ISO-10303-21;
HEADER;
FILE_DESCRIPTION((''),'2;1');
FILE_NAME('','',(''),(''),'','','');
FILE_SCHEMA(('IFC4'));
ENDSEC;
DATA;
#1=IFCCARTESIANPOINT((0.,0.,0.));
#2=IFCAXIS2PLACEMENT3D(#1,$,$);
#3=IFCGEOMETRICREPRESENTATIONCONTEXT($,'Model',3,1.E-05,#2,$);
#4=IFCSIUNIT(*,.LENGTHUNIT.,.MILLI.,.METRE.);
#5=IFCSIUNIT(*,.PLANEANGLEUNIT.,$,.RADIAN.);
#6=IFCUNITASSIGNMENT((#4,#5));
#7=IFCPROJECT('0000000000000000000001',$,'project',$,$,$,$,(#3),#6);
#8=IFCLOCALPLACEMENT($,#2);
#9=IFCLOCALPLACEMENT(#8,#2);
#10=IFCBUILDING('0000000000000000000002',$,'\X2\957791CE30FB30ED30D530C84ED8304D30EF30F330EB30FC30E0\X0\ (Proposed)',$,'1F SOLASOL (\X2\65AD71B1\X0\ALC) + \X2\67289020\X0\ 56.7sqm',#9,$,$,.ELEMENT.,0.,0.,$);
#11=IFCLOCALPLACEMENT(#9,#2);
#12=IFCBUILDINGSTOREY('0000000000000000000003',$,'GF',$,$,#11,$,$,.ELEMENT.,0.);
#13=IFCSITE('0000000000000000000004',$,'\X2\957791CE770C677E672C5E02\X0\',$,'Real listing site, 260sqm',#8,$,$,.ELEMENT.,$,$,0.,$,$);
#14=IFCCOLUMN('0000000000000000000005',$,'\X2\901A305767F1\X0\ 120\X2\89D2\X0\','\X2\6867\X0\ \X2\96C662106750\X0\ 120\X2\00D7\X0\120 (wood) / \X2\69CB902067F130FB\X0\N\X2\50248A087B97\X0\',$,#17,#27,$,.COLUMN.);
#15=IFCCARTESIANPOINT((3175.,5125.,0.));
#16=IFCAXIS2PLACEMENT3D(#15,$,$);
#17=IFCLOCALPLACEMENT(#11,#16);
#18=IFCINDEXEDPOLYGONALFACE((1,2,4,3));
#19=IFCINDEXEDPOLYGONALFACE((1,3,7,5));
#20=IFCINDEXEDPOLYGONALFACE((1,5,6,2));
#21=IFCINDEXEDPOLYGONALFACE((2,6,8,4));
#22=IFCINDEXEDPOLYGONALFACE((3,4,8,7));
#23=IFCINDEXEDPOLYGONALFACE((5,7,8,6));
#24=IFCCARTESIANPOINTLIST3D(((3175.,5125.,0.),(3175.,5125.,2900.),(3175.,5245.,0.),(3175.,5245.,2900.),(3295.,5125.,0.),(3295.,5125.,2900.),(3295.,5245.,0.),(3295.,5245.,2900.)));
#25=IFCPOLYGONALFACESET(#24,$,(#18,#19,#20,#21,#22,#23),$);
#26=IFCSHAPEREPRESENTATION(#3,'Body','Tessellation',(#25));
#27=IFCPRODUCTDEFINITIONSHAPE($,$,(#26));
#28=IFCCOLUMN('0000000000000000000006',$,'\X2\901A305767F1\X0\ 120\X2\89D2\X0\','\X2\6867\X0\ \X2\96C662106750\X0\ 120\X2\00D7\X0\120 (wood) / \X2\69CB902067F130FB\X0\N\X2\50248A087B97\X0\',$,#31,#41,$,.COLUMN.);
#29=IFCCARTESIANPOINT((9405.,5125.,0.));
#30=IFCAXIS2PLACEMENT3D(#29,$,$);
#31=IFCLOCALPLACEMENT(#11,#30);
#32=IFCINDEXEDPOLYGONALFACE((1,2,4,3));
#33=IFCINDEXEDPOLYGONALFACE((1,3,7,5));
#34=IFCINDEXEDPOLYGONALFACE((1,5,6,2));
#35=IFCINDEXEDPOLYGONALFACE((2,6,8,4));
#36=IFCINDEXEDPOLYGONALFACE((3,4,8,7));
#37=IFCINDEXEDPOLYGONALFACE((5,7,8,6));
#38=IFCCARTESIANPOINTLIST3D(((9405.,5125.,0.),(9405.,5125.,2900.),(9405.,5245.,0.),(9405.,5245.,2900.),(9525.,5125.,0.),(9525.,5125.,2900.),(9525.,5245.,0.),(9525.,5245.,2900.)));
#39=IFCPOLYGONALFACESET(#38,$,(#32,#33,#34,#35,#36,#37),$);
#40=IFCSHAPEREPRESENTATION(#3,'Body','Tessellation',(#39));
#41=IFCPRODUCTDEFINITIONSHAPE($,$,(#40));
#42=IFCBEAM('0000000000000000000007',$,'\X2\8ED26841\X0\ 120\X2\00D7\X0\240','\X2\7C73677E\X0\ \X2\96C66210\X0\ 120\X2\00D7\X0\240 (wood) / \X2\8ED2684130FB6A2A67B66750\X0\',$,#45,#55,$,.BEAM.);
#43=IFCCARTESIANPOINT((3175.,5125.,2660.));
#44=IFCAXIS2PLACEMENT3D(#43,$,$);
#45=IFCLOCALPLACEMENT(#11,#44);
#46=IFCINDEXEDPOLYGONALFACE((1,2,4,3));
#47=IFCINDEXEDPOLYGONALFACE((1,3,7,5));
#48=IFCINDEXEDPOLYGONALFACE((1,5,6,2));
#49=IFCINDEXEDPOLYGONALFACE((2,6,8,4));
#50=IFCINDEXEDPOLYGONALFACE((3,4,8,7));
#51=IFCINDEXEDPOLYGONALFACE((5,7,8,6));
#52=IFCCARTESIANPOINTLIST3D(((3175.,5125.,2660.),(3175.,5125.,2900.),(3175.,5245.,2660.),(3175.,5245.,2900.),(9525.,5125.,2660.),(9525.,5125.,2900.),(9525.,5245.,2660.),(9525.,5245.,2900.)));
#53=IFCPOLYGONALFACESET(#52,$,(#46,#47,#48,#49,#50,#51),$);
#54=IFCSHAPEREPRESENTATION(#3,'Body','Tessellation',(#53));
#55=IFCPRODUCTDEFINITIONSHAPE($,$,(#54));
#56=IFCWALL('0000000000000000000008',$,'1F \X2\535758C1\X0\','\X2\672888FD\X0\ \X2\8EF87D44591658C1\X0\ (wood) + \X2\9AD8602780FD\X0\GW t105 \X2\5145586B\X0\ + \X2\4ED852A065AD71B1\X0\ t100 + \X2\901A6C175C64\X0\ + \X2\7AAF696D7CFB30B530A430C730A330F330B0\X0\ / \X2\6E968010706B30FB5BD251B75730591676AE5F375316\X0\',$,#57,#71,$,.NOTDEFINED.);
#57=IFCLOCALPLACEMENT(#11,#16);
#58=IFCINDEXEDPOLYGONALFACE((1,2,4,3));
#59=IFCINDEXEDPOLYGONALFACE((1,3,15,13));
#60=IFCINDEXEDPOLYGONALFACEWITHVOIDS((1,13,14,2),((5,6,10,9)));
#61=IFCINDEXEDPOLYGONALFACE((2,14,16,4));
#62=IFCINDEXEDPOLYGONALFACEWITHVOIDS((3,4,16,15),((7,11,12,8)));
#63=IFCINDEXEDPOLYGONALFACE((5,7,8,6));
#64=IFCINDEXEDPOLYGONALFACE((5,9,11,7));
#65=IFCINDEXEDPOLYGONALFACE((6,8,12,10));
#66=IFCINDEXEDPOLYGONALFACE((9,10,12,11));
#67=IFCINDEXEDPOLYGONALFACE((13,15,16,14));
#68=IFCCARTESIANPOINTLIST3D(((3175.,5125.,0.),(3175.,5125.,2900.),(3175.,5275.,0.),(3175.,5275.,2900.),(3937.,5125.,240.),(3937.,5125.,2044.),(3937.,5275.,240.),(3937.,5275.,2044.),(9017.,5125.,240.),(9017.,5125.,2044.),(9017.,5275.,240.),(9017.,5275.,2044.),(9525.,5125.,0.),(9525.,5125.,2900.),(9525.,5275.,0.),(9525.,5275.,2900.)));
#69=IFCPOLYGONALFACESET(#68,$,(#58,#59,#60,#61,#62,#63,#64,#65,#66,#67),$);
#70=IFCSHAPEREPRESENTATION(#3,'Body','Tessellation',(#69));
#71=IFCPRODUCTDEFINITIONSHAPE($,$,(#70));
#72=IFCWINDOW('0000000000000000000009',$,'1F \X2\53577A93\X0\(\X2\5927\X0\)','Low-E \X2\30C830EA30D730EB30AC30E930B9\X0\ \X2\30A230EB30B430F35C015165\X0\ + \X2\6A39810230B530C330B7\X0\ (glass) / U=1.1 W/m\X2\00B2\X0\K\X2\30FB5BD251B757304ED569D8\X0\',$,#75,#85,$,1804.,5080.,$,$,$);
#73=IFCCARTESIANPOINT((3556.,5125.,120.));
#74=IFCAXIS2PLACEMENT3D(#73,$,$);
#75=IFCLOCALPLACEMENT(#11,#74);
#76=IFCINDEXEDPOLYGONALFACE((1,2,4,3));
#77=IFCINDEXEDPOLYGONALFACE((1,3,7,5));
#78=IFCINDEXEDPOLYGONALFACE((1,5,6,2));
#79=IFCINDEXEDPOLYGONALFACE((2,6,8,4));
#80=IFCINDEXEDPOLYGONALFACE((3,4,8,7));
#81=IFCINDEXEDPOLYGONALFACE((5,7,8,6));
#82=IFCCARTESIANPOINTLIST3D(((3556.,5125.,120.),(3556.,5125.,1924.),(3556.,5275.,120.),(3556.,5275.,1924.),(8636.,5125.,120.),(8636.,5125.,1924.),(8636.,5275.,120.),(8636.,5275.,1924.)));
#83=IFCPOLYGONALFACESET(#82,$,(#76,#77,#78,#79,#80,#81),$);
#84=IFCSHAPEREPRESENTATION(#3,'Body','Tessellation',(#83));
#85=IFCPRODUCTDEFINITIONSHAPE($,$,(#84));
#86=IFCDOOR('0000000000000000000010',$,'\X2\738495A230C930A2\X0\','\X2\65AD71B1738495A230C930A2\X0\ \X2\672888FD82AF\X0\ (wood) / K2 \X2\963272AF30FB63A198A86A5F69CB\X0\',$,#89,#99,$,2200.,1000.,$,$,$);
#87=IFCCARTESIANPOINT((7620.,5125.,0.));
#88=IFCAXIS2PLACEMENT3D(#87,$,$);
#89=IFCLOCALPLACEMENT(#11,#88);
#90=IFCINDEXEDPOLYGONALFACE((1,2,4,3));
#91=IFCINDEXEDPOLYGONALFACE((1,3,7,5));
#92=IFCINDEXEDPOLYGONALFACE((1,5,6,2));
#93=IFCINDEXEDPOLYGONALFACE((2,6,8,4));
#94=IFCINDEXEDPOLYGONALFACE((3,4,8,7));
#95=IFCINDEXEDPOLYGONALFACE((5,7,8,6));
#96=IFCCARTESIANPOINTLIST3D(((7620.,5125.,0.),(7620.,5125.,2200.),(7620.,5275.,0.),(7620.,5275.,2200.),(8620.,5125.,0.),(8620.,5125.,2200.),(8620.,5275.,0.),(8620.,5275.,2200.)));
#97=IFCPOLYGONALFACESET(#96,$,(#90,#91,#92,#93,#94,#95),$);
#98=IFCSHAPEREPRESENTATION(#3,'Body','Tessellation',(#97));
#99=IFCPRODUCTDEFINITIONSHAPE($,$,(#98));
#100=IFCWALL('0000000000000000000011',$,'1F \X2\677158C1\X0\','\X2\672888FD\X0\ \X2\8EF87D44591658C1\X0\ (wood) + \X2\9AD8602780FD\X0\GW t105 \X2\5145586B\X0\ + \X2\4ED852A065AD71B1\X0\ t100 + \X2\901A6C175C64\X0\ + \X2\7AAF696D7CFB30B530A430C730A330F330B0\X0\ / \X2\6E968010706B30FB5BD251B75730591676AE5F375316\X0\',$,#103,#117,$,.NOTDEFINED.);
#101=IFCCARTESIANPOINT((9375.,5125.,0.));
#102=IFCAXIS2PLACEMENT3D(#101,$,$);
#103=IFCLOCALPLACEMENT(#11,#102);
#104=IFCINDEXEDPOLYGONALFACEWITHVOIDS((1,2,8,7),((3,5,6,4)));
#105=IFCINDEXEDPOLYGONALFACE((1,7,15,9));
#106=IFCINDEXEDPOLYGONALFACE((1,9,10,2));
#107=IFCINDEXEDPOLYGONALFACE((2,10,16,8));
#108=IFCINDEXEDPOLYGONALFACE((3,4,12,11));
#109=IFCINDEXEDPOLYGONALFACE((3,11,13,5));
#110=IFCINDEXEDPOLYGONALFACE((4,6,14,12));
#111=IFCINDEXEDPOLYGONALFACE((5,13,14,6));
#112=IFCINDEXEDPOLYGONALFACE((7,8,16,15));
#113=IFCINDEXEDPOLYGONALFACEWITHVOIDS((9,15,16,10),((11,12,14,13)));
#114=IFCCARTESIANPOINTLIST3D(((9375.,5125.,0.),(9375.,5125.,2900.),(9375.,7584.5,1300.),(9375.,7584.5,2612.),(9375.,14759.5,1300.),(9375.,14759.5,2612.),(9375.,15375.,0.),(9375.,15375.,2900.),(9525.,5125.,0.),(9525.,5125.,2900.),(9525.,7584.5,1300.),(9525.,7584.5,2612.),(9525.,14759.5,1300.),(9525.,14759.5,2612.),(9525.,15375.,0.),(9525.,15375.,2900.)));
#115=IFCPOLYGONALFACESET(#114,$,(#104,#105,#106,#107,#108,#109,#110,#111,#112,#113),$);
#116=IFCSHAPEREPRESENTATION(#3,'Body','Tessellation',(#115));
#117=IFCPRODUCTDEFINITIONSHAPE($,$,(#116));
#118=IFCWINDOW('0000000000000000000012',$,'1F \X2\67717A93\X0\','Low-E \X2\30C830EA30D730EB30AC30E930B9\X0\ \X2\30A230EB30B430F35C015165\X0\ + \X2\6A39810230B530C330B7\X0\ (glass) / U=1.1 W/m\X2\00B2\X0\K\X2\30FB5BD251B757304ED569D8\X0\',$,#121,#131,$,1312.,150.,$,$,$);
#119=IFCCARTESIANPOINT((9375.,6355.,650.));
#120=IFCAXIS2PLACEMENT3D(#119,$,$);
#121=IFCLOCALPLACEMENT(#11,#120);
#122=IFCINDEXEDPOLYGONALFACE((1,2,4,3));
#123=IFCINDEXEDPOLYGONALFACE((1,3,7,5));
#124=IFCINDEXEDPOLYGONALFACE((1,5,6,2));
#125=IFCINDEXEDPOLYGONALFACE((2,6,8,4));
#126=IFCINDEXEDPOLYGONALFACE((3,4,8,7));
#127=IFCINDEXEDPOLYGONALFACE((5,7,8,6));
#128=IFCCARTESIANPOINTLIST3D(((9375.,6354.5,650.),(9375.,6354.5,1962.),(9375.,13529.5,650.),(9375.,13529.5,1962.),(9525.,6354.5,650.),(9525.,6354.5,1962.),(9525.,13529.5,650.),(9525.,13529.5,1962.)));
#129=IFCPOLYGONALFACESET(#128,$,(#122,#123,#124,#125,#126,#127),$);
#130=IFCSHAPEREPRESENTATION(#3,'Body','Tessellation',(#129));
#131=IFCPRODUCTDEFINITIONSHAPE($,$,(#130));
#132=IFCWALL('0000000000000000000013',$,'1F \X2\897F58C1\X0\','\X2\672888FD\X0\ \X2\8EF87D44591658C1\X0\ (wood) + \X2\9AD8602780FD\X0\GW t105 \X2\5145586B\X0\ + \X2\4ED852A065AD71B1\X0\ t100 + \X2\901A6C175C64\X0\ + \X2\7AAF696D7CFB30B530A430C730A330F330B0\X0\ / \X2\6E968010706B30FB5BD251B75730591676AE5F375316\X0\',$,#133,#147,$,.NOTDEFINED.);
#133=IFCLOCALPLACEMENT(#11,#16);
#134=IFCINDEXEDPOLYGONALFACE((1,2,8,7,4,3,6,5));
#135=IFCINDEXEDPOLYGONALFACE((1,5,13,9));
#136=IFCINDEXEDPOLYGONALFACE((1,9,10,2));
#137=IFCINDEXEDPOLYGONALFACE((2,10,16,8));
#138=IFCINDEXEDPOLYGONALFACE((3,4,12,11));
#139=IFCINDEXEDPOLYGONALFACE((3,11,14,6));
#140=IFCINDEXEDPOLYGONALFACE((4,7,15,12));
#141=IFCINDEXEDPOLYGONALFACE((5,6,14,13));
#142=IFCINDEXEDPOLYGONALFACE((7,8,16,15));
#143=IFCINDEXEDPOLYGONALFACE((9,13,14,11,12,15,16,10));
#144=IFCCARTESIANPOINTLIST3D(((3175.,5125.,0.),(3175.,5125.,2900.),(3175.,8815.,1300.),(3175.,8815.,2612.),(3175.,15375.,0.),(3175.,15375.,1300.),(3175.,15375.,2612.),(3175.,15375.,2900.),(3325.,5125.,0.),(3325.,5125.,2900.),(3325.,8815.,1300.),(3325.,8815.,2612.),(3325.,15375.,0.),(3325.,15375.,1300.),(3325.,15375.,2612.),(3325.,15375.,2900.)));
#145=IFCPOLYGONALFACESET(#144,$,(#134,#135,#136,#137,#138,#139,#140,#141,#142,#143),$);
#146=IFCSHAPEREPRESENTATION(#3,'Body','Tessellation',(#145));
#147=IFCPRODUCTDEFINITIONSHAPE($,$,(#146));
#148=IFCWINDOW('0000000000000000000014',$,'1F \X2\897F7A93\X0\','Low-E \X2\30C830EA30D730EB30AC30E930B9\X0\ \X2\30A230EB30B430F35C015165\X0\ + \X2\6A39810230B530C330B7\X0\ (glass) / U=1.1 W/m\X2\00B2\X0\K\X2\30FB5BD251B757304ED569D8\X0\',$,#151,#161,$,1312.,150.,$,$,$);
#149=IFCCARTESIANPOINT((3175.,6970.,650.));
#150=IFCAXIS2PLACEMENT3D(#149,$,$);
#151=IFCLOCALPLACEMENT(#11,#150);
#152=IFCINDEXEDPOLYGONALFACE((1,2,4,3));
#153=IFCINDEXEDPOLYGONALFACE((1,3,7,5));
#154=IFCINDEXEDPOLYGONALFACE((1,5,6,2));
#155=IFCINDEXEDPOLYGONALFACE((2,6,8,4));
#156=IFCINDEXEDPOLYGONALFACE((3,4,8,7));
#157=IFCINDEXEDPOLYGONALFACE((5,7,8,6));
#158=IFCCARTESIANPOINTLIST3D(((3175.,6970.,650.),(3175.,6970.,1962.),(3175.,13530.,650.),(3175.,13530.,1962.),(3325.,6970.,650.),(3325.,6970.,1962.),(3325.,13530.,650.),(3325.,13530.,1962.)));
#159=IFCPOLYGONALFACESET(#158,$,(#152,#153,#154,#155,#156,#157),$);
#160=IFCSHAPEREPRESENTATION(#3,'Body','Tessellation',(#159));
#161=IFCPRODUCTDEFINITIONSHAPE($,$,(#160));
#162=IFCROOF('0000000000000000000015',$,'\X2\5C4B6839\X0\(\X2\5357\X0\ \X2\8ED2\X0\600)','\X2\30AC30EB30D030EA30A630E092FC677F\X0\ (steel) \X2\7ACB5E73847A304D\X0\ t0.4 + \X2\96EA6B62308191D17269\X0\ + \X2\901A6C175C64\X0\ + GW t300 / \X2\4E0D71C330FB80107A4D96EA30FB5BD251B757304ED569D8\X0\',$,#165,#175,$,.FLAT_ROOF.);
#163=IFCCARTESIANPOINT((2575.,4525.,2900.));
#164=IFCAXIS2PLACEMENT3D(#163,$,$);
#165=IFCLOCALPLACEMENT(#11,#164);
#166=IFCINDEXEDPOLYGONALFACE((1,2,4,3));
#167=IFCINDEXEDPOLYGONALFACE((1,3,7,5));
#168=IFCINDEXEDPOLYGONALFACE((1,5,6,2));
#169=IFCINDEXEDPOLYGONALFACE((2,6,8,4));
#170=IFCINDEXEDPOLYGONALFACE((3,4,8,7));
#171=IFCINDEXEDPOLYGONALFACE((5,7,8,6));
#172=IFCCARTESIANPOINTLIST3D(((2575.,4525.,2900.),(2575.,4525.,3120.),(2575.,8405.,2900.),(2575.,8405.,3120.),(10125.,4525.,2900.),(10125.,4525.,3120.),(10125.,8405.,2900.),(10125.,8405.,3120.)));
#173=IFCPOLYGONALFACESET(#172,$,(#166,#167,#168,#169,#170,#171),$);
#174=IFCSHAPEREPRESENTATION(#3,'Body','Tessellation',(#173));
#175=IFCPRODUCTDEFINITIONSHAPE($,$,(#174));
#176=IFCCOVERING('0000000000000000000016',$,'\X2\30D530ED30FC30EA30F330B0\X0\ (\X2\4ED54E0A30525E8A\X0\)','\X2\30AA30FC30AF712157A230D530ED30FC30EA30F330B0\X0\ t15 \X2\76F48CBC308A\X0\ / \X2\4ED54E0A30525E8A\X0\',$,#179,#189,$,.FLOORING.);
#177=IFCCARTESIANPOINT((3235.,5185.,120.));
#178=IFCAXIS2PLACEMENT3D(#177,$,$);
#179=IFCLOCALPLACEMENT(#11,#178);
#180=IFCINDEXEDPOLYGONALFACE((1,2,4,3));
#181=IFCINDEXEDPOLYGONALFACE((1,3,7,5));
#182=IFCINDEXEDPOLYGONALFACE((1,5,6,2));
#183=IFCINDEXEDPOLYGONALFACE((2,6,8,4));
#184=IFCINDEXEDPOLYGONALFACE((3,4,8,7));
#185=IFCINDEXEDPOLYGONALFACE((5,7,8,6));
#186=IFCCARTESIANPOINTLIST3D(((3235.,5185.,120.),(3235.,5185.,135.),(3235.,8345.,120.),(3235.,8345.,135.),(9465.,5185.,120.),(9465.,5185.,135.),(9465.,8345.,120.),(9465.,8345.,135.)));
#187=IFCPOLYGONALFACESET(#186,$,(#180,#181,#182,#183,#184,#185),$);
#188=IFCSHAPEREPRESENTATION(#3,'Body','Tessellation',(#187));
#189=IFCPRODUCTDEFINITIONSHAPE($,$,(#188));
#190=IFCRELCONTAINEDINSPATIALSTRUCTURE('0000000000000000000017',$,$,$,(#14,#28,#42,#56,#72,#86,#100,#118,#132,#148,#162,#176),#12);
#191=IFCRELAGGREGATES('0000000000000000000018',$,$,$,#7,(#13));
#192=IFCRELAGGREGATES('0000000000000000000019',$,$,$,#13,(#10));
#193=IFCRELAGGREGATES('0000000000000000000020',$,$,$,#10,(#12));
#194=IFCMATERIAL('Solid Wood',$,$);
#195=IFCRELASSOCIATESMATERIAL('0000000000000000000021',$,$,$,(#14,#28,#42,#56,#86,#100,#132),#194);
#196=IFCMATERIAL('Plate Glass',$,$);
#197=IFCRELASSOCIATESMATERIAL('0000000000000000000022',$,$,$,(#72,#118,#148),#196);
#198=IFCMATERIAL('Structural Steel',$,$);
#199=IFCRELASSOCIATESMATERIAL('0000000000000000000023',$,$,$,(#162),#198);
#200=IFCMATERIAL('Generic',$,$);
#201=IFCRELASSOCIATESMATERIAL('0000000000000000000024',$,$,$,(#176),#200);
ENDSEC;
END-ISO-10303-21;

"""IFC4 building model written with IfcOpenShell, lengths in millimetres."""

from ifc_helpers import new_model, si_unit, frame, frame_2d, origin, place, context, project, spatial, rectangle, extrude, material, element, fill, save


model = new_model("IFC4")

# Units and contexts
model_context = context("Model", 3, precision=1e-05, world=origin())
ifc_project = project(units=[si_unit("LENGTHUNIT", "METRE", prefix="MILLI"), si_unit("PLANEANGLEUNIT", "RADIAN")], contexts=[model_context])

# Site, building, storey
site_placement = place(None, origin())
site = spatial("IfcSite", under=ifc_project, at=site_placement, Name="長野県松本市", ObjectType="Real listing site, 260sqm", CompositionType="ELEMENT", RefElevation=0.0)
building_placement = place(site_placement, origin())
building = spatial("IfcBuilding", under=site, at=building_placement, Name="長野・ロフト付きワンルーム (Proposed)", ObjectType="1F SOLASOL (断熱ALC) + 木造 56.7sqm", CompositionType="ELEMENT", ElevationOfRefHeight=0.0, ElevationOfTerrain=0.0)
storey_placement = place(building_placement, origin())
storey = spatial("IfcBuildingStorey", under=building, at=storey_placement, Name="GF", CompositionType="ELEMENT", Elevation=0.0)

# Columns
ifc_material_1 = material(Name="Solid Wood")
column_1_placement = place(storey_placement, frame((3175.0, 5125.0, 0.0)))
element("IfcColumn", 1, at=column_1_placement, inside=storey, material=ifc_material_1, Name="通し柱 120角", Description="桧 集成材 120×120 (wood) / 構造柱・N値計算", PredefinedType="COLUMN", context=model_context, shape_type="SweptSolid", body=[
    extrude(rectangle(XDim=120.0, YDim=120.0, at=frame_2d((60.0, 60.0))), frame((3175.0, 5125.0, 0.0)), (0.0, 0.0, 1.0), 2900.0),
])
column_2_placement = place(storey_placement, frame((9405.0, 5125.0, 0.0)))
element("IfcColumn", 2, at=column_2_placement, inside=storey, material=ifc_material_1, Name="通し柱 120角", Description="桧 集成材 120×120 (wood) / 構造柱・N値計算", PredefinedType="COLUMN", context=model_context, shape_type="SweptSolid", body=[
    extrude(rectangle(XDim=120.0, YDim=120.0, at=frame_2d((60.0, 60.0))), frame((9405.0, 5125.0, 0.0)), (0.0, 0.0, 1.0), 2900.0),
])

# Beam
beam_1_placement = place(storey_placement, frame((3175.0, 5125.0, 2660.0)))
element("IfcBeam", 3, at=beam_1_placement, inside=storey, material=ifc_material_1, Name="軒桁 120×240", Description="米松 集成 120×240 (wood) / 軒桁・横架材", PredefinedType="BEAM", context=model_context, shape_type="SweptSolid", body=[
    extrude(rectangle(XDim=6350.0, YDim=120.0, at=frame_2d((3175.0, 60.0))), frame((3175.0, 5125.0, 2660.0)), (0.0, 0.0, 1.0), 240.0),
])

# Wall, openings, window, door
wall_1_placement = place(storey_placement, frame((3175.0, 5125.0, 0.0)))
wall_1 = element("IfcWall", 4, at=wall_1_placement, inside=storey, material=ifc_material_1, Name="1F 南壁", Description="木製 軸組外壁 (wood) + 高性能GW t105 充填 + 付加断熱 t100 + 通気層 + 窯業系サイディング / 準耐火・寒冷地外皮強化", PredefinedType="NOTDEFINED", context=model_context, shape_type="SweptSolid", body=[
    extrude(rectangle(XDim=6350.0, YDim=150.0, at=frame_2d((3175.0, 75.0))), frame((3175.0, 5125.0, 0.0)), (0.0, 0.0, 1.0), 2900.0),
])
opening_1_placement = place(storey_placement, frame((3556.0, 5125.0, 120.0)))
opening_1 = element("IfcOpeningElement", 5, at=opening_1_placement, cuts=wall_1, PredefinedType="NOTDEFINED", context=model_context, shape_type="SweptSolid", body=[
    extrude(rectangle(XDim=5080.0, YDim=150.0, at=frame_2d((2540.0, 75.0))), frame((3556.0, 5125.0, 120.0)), (0.0, 0.0, 1.0), 1804.0),
])
opening_2_placement = place(storey_placement, frame((7620.0, 5125.0, 0.0)))
opening_2 = element("IfcOpeningElement", 6, at=opening_2_placement, cuts=wall_1, PredefinedType="NOTDEFINED", context=model_context, shape_type="SweptSolid", body=[
    extrude(rectangle(XDim=1000.0, YDim=150.0, at=frame_2d((500.0, 75.0))), frame((7620.0, 5125.0, 0.0)), (0.0, 0.0, 1.0), 2200.0),
])
ifc_material_2 = material(Name="Plate Glass")
window_1_placement = place(storey_placement, frame((3556.0, 5125.0, 120.0)))
window_1 = element("IfcWindow", 7, at=window_1_placement, inside=storey, material=ifc_material_2, Name="1F 南窓(大)", Description="Low-E トリプルガラス アルゴン封入 + 樹脂サッシ (glass) / U=1.1 W/m²K・寒冷地仕様", OverallHeight=1804.0, OverallWidth=5080.0, context=model_context, shape_type="SweptSolid", body=[
    extrude(rectangle(XDim=5080.0, YDim=150.0, at=frame_2d((2540.0, 75.0))), frame((3556.0, 5125.0, 120.0)), (0.0, 0.0, 1.0), 1804.0),
])
fill(opening_1, window_1)
door_placement = place(storey_placement, frame((7620.0, 5125.0, 0.0)))
door = element("IfcDoor", 8, at=door_placement, inside=storey, material=ifc_material_1, Name="玄関ドア", Description="断熱玄関ドア 木製芯 (wood) / K2 防犯・採風機構", OverallHeight=2200.0, OverallWidth=1000.0, context=model_context, shape_type="SweptSolid", body=[
    extrude(rectangle(XDim=1000.0, YDim=150.0, at=frame_2d((500.0, 75.0))), frame((7620.0, 5125.0, 0.0)), (0.0, 0.0, 1.0), 2200.0),
])
fill(opening_2, door)

# Walls, openings, windows
wall_2_placement = place(storey_placement, frame((9375.0, 5125.0, 0.0)))
wall_2 = element("IfcWall", 9, at=wall_2_placement, inside=storey, material=ifc_material_1, Name="1F 東壁", Description="木製 軸組外壁 (wood) + 高性能GW t105 充填 + 付加断熱 t100 + 通気層 + 窯業系サイディング / 準耐火・寒冷地外皮強化", PredefinedType="NOTDEFINED", context=model_context, shape_type="SweptSolid", body=[
    extrude(rectangle(XDim=150.0, YDim=10250.0, at=frame_2d((75.0, 5125.0))), frame((9375.0, 5125.0, 0.0)), (0.0, 0.0, 1.0), 2900.0),
])
opening_3_placement = place(storey_placement, frame((9375.0, 6355.0, 650.0)))
opening_3 = element("IfcOpeningElement", 10, at=opening_3_placement, cuts=wall_2, PredefinedType="NOTDEFINED", context=model_context, shape_type="SweptSolid", body=[
    extrude(rectangle(XDim=150.0, YDim=7175.0, at=frame_2d((75.0, 3587.0))), frame((9375.0, 6355.0, 650.0)), (0.0, 0.0, 1.0), 1312.0),
])
window_2_placement = place(storey_placement, frame((9375.0, 6355.0, 650.0)))
window_2 = element("IfcWindow", 11, at=window_2_placement, inside=storey, material=ifc_material_2, Name="1F 東窓", Description="Low-E トリプルガラス アルゴン封入 + 樹脂サッシ (glass) / U=1.1 W/m²K・寒冷地仕様", OverallHeight=1312.0, OverallWidth=150.0, context=model_context, shape_type="SweptSolid", body=[
    extrude(rectangle(XDim=150.0, YDim=7175.0, at=frame_2d((75.0, 3587.0))), frame((9375.0, 6355.0, 650.0)), (0.0, 0.0, 1.0), 1312.0),
])
fill(opening_3, window_2)
wall_3_placement = place(storey_placement, frame((3175.0, 5125.0, 0.0)))
wall_3 = element("IfcWall", 12, at=wall_3_placement, inside=storey, material=ifc_material_1, Name="1F 西壁", Description="木製 軸組外壁 (wood) + 高性能GW t105 充填 + 付加断熱 t100 + 通気層 + 窯業系サイディング / 準耐火・寒冷地外皮強化", PredefinedType="NOTDEFINED", context=model_context, shape_type="SweptSolid", body=[
    extrude(rectangle(XDim=150.0, YDim=10250.0, at=frame_2d((75.0, 5125.0))), frame((3175.0, 5125.0, 0.0)), (0.0, 0.0, 1.0), 2900.0),
])
opening_4_placement = place(storey_placement, frame((3175.0, 6970.0, 650.0)))
opening_4 = element("IfcOpeningElement", 13, at=opening_4_placement, cuts=wall_3, PredefinedType="NOTDEFINED", context=model_context, shape_type="SweptSolid", body=[
    extrude(rectangle(XDim=150.0, YDim=6560.0, at=frame_2d((75.0, 3280.0))), frame((3175.0, 6970.0, 650.0)), (0.0, 0.0, 1.0), 1312.0),
])
window_3_placement = place(storey_placement, frame((3175.0, 6970.0, 650.0)))
window_3 = element("IfcWindow", 14, at=window_3_placement, inside=storey, material=ifc_material_2, Name="1F 西窓", Description="Low-E トリプルガラス アルゴン封入 + 樹脂サッシ (glass) / U=1.1 W/m²K・寒冷地仕様", OverallHeight=1312.0, OverallWidth=150.0, context=model_context, shape_type="SweptSolid", body=[
    extrude(rectangle(XDim=150.0, YDim=6560.0, at=frame_2d((75.0, 3280.0))), frame((3175.0, 6970.0, 650.0)), (0.0, 0.0, 1.0), 1312.0),
])
fill(opening_4, window_3)

# Roof
ifc_material_3 = material(Name="Structural Steel")
roof_placement = place(storey_placement, frame((2575.0, 4525.0, 2900.0)))
element("IfcRoof", 15, at=roof_placement, inside=storey, material=ifc_material_3, Name="屋根(南 軒600)", Description="ガルバリウム鋼板 (steel) 立平葺き t0.4 + 雪止め金物 + 通気層 + GW t300 / 不燃・耐積雪・寒冷地仕様", PredefinedType="FLAT_ROOF", context=model_context, shape_type="SweptSolid", body=[
    extrude(rectangle(XDim=7550.0, YDim=3880.0, at=frame_2d((3775.0, 1940.0))), frame((2575.0, 4525.0, 2900.0)), (0.0, 0.0, 1.0), 220.0),
])

# Covering
ifc_material_4 = material(Name="Generic")
covering_1_placement = place(storey_placement, frame((3235.0, 5185.0, 120.0)))
element("IfcCovering", 16, at=covering_1_placement, inside=storey, material=ifc_material_4, Name="フローリング (仕上げ床)", Description="オーク無垢フローリング t15 直貼り / 仕上げ床", PredefinedType="FLOORING", context=model_context, shape_type="SweptSolid", body=[
    extrude(rectangle(XDim=6230.0, YDim=3160.0, at=frame_2d((3115.0, 1580.0))), frame((3235.0, 5185.0, 120.0)), (0.0, 0.0, 1.0), 15.0),
])

save(model, "model.ifc")
